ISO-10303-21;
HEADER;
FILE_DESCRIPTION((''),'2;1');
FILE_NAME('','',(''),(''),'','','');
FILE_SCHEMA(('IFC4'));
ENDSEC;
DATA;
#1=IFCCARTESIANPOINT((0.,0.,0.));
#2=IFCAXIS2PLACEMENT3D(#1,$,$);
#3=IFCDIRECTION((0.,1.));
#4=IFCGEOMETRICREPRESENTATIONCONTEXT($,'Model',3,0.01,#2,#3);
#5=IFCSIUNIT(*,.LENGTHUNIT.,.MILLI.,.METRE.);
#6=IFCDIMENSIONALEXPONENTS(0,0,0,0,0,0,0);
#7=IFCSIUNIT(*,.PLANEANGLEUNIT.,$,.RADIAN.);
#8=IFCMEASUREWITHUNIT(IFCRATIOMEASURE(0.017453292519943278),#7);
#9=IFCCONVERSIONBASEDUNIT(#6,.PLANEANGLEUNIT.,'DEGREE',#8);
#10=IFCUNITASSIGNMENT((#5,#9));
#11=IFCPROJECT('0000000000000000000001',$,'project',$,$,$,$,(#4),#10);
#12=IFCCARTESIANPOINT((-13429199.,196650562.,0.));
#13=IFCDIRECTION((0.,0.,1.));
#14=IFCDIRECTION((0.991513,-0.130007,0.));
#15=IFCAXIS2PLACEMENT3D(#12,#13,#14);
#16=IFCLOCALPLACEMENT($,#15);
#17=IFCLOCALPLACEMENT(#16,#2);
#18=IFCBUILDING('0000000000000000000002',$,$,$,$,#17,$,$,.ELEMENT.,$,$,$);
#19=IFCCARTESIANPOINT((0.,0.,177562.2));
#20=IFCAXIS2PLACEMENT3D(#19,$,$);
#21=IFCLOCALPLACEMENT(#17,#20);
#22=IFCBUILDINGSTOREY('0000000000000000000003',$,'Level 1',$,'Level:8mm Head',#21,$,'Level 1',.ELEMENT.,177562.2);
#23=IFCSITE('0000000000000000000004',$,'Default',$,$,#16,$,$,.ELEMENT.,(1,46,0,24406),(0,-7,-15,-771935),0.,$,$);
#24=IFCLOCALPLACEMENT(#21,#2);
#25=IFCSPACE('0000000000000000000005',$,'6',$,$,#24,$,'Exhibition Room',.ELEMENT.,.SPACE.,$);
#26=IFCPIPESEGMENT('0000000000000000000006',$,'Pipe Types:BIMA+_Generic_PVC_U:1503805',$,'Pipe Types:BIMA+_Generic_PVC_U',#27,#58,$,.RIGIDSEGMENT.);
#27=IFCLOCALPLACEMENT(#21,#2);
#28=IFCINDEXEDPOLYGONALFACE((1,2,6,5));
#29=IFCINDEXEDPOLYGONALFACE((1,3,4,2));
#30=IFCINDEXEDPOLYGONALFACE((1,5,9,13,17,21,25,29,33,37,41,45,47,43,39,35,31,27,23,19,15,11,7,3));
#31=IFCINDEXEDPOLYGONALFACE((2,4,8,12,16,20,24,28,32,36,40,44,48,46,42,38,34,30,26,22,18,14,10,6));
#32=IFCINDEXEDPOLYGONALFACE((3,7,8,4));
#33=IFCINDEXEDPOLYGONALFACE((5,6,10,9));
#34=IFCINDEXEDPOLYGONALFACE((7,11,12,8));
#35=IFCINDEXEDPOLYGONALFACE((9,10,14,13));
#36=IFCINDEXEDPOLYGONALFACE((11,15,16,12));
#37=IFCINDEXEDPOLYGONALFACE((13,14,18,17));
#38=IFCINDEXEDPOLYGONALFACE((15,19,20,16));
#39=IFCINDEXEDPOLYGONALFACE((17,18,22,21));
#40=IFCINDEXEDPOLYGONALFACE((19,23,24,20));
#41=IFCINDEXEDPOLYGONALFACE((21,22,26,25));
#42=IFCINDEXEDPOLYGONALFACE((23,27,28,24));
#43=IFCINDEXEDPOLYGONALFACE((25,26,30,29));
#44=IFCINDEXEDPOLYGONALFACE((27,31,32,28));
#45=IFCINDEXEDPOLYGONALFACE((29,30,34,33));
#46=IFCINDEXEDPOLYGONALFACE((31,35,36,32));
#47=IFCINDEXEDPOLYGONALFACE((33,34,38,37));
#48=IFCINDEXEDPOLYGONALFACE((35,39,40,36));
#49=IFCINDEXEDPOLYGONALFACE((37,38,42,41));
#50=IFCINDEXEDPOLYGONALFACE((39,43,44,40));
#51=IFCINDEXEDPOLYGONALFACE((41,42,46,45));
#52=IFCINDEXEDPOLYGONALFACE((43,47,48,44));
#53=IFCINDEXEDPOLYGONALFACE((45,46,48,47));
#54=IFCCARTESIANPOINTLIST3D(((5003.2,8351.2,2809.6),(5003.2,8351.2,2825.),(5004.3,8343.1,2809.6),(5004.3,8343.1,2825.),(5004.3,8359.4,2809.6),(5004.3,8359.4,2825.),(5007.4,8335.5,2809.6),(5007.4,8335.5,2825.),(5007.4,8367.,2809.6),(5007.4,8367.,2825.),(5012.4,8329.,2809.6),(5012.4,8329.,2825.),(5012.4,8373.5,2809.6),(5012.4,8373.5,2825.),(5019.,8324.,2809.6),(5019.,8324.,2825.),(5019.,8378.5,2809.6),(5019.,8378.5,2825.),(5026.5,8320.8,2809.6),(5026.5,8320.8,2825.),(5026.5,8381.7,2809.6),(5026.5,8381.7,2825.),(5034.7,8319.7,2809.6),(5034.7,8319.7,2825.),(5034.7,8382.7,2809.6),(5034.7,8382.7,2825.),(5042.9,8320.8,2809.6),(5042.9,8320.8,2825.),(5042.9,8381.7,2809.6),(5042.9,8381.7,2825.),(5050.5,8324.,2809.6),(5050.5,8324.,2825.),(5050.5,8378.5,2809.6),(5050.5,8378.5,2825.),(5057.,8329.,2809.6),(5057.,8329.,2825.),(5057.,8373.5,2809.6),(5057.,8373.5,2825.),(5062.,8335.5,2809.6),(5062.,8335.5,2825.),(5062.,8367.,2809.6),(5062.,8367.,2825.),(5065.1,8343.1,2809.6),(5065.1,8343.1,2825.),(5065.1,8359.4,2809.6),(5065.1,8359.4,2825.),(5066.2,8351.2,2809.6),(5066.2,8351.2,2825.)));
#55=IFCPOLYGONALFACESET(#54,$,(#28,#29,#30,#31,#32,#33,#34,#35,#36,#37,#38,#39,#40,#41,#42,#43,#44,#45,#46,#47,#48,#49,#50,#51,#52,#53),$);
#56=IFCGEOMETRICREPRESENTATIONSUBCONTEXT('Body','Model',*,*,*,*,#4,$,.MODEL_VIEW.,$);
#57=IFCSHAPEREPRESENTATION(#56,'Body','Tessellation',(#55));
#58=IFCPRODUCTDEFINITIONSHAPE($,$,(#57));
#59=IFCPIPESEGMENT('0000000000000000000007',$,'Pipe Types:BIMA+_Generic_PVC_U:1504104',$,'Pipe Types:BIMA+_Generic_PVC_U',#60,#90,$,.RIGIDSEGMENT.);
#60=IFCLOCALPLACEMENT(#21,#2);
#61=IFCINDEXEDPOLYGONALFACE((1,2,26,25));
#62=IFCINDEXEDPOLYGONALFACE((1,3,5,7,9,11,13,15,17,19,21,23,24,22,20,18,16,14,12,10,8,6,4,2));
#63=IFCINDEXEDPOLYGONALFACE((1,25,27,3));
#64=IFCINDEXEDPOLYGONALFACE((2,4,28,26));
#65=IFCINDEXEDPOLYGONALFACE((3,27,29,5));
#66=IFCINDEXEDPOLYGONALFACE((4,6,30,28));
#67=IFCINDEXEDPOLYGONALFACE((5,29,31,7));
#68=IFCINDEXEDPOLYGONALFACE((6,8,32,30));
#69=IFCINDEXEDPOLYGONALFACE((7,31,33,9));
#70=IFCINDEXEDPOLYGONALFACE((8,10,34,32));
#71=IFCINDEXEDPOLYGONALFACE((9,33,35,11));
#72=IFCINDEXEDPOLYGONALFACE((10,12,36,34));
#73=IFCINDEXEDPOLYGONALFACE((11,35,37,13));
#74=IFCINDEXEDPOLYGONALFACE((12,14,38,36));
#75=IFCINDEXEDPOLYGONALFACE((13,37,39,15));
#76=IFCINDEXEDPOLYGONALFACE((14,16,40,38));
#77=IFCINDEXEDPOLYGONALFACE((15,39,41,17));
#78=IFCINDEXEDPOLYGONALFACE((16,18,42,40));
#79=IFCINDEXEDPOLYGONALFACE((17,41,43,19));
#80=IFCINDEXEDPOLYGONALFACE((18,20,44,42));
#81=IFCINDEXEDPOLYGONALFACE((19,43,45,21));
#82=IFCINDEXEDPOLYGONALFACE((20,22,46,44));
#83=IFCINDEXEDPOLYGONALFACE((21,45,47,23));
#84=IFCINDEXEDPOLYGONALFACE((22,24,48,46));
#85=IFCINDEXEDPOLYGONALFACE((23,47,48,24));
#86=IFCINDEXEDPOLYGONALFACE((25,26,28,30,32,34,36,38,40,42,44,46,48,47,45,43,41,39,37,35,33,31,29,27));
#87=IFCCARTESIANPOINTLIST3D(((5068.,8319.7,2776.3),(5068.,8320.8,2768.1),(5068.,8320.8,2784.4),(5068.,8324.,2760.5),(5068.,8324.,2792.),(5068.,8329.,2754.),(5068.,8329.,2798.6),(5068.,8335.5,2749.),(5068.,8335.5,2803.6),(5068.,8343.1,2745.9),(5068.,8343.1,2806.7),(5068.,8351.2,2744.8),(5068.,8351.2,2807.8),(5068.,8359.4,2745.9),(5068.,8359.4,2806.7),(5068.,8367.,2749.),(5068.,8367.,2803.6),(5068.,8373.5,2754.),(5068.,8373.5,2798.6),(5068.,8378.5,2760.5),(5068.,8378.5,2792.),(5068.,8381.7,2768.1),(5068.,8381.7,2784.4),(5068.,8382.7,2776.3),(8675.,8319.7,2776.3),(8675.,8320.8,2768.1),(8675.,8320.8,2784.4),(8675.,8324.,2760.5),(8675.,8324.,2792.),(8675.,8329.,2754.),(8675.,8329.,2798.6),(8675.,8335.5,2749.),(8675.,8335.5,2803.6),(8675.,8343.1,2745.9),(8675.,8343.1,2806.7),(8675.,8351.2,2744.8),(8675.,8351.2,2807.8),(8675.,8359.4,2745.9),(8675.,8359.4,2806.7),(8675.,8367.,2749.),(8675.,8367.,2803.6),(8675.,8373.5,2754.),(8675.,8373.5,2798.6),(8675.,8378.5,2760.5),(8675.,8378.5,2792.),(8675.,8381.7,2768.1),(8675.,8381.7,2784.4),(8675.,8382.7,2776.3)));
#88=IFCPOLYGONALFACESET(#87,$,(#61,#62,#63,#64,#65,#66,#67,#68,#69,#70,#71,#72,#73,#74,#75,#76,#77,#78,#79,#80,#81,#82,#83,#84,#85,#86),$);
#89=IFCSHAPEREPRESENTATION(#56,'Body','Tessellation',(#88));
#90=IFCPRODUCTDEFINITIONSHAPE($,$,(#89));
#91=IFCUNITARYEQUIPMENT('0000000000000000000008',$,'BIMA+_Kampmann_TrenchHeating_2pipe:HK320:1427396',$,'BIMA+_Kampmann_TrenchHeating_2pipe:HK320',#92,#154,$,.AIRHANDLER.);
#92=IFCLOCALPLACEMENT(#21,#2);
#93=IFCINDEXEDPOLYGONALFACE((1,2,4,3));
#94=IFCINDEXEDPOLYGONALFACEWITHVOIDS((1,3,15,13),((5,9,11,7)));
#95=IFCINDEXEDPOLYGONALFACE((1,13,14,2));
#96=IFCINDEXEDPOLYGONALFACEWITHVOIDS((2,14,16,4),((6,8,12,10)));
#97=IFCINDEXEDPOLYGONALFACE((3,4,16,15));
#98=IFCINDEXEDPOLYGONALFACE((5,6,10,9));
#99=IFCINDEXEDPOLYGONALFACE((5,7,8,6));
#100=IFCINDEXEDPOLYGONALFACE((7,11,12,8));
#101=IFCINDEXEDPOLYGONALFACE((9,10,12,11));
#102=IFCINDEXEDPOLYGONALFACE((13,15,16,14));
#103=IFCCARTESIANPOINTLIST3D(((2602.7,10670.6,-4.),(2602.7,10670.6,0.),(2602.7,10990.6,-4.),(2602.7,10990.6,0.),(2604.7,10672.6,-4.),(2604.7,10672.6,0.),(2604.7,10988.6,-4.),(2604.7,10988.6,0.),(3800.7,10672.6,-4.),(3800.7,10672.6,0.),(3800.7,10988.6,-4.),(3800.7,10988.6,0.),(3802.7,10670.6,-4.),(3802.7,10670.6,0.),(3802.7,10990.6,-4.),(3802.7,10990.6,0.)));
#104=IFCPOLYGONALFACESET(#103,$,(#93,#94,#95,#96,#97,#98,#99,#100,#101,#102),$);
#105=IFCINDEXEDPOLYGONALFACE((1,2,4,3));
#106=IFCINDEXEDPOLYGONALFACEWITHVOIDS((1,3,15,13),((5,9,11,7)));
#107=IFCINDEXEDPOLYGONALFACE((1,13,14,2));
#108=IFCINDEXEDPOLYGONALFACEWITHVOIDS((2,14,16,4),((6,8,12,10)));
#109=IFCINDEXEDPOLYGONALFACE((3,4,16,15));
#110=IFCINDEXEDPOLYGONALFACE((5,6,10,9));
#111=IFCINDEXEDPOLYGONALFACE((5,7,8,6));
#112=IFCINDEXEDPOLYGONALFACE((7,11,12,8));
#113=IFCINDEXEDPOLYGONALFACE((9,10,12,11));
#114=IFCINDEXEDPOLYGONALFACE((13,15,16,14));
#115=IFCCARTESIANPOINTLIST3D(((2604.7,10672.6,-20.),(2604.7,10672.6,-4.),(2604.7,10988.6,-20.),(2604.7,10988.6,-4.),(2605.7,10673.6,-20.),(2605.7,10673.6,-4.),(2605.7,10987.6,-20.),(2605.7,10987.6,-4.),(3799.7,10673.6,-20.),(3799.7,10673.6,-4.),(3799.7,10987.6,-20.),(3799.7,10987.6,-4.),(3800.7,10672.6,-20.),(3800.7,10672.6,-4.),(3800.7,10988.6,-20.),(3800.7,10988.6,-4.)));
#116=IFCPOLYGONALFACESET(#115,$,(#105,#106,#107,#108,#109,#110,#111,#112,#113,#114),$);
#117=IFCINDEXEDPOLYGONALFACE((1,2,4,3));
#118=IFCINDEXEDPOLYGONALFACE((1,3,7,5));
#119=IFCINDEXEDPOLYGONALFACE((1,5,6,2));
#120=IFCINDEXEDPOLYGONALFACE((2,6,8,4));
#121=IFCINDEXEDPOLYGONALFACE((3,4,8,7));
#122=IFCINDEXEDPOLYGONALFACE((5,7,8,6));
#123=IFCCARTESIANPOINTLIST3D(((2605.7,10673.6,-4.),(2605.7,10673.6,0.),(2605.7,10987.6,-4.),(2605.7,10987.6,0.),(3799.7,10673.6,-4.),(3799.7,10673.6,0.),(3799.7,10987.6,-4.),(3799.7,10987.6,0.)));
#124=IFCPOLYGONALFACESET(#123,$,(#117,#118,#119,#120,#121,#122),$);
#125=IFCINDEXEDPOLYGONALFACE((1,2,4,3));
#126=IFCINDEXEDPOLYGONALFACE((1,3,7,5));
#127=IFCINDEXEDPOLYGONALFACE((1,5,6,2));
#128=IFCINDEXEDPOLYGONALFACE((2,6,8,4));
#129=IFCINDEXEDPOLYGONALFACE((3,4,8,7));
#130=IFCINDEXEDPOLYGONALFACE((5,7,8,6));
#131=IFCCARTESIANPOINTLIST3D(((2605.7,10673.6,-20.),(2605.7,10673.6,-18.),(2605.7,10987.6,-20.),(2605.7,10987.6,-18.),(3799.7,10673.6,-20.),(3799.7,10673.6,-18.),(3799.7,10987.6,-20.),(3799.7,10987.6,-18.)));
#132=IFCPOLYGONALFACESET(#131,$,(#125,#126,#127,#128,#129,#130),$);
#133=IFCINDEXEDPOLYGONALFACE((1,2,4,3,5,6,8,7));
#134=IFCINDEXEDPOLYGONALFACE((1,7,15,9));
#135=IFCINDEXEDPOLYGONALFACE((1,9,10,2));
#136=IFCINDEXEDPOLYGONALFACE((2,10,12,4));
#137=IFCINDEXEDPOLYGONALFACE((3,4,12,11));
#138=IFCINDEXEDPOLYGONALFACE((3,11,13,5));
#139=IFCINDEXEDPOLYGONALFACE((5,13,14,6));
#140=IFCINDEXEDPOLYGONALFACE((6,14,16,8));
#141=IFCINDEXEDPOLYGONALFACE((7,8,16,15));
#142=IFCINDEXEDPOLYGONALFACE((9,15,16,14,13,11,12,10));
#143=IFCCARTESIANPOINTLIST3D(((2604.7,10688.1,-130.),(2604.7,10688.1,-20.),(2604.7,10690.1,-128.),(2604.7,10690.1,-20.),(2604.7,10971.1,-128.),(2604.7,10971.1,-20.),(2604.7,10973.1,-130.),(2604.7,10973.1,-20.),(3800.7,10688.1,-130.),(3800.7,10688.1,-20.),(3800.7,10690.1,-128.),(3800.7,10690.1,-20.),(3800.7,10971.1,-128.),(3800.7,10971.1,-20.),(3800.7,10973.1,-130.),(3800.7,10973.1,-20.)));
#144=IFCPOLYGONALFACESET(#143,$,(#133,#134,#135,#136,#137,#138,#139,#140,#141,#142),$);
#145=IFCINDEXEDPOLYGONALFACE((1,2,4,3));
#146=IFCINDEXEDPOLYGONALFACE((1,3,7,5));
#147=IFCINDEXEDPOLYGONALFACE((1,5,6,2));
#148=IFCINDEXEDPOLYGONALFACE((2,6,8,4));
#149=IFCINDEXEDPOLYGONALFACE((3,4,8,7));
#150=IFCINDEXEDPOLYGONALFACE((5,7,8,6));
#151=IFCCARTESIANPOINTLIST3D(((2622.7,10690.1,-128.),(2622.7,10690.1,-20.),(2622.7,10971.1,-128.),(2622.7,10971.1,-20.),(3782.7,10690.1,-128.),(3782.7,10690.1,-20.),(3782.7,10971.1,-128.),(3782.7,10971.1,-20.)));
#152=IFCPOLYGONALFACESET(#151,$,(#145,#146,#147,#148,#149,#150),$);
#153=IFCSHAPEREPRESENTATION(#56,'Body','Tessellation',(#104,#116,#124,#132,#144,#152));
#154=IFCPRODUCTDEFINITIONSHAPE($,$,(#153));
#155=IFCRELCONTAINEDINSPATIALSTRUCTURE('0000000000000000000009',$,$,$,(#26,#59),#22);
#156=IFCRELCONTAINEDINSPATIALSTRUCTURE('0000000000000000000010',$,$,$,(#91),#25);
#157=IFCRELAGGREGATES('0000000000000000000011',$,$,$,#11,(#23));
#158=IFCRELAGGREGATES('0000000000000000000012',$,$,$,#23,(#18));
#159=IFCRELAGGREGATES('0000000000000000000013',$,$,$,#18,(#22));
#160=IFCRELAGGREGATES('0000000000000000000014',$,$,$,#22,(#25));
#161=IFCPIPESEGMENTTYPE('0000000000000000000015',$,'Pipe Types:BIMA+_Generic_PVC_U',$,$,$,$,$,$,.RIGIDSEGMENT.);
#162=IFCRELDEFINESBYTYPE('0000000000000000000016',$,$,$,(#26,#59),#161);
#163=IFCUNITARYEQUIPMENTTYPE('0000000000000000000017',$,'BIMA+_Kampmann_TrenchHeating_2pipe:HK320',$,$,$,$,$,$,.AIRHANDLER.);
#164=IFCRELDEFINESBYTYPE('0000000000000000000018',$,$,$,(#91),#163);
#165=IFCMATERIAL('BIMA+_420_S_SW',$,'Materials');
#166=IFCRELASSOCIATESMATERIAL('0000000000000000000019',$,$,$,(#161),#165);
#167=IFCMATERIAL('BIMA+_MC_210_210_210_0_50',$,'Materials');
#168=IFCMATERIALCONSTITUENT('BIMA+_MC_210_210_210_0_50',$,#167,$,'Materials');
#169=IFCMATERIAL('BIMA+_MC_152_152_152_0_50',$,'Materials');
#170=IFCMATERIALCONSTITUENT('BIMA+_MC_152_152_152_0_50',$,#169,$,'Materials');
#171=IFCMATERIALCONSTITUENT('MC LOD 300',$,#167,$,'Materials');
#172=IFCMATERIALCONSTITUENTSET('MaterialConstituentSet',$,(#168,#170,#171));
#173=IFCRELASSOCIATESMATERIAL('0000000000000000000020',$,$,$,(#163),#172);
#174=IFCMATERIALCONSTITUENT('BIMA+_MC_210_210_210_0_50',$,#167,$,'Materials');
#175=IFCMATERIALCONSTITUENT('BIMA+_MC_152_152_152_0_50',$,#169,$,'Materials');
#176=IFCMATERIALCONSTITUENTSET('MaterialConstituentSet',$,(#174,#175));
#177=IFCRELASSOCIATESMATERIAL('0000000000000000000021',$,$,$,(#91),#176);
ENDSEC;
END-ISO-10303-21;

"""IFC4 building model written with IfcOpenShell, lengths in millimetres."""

from ifc_helpers import new_model, entity, si_unit, converted_unit, direction, frame, origin, place, context, subcontext, project, spatial, arc, indexed_curve, outline, extrude, source, transform, mapped, material, constituent, constituent_set, type_object, type_shapes, element, save


model = new_model("IFC4")

# Units and contexts
model_context = context("Model", 3, precision=0.01, world=origin(), true_north=direction((0.0, 1.0)))
body_context = subcontext(model_context, "Body", "Model", "MODEL_VIEW")
ifc_project = project(units=[si_unit("LENGTHUNIT", "METRE", prefix="MILLI"), converted_unit("PLANEANGLEUNIT", "DEGREE", entity("IfcRatioMeasure", 0.017453292519943278), si_unit("PLANEANGLEUNIT", "RADIAN"), dimensions=[0, 0, 0, 0, 0, 0, 0])], contexts=[model_context])

# Site, building, storey
site_placement = place(None, frame((-13429199.0, 196650562.0, 0.0), z_axis=(0.0, 0.0, 1.0), x_axis=(0.991513, -0.130007, 0.0)))
site = spatial("IfcSite", under=ifc_project, at=site_placement, Name="Default", CompositionType="ELEMENT", RefLatitude=(1, 46, 0, 24406), RefLongitude=(0, -7, -15, -771935), RefElevation=0.0)
building_placement = place(site_placement, origin())
building = spatial("IfcBuilding", under=site, at=building_placement, CompositionType="ELEMENT")
storey_placement = place(building_placement, frame((0.0, 0.0, 177562.2)))
storey = spatial("IfcBuildingStorey", under=building, at=storey_placement, Name="Level 1", ObjectType="Level:8mm Head", LongName="Level 1", CompositionType="ELEMENT", Elevation=177562.2)

# Pipe segments
ifc_material_1 = material(Name="BIMA+_420_S_SW", Category="Materials")
pipe_segment_type_1 = type_object("IfcPipeSegmentType", Name="Pipe Types:BIMA+_Generic_PVC_U", PredefinedType="RIGIDSEGMENT", material=ifc_material_1)
pipe_segment_1_placement = place(storey_placement, frame((5001.6, 8318.2, 2825.0)))
element("IfcPipeSegment", 1, at=pipe_segment_1_placement, inside=storey, type_object=pipe_segment_type_1, Name="Pipe Types:BIMA+_Generic_PVC_U:1503805", ObjectType="Pipe Types:BIMA+_Generic_PVC_U", PredefinedType="RIGIDSEGMENT", context=body_context, shape_type="SweptSolid", body=[
    extrude(outline(indexed_curve([(31.5, 0.0), (22.3, 22.3), (0.0, 31.5), (-22.3, 22.3), (-31.5, 0.0), (-22.3, -22.3), (0.0, -31.5), (22.3, -22.3)], segments=[arc(1, 2, 3), arc(3, 4, 5), arc(5, 6, 7), arc(7, 8, 1)], self_intersect=False)), frame((33.1, 33.1, -15.4)), (0.0, 0.0, 1.0), 15.4),
])
pipe_segment_2_placement = place(storey_placement, frame((5068.0, 8318.2, 2743.2)))
element("IfcPipeSegment", 2, at=pipe_segment_2_placement, inside=storey, type_object=pipe_segment_type_1, Name="Pipe Types:BIMA+_Generic_PVC_U:1504104", ObjectType="Pipe Types:BIMA+_Generic_PVC_U", PredefinedType="RIGIDSEGMENT", context=body_context, shape_type="SweptSolid", body=[
    extrude(outline(indexed_curve([(31.5, 0.0), (22.3, 22.3), (0.0, 31.5), (-22.3, 22.3), (-31.5, 0.0), (-22.3, -22.3), (0.0, -31.5), (22.3, -22.3)], segments=[arc(1, 2, 3), arc(3, 4, 5), arc(5, 6, 7), arc(7, 8, 1)], self_intersect=False)), frame((0.0, 33.1, 33.1), z_axis=(1.0, 0.0, 0.0), x_axis=(0.0, -1.0, 0.0)), (0.0, 0.0, 1.0), 3607.0),
])

# Shared definitions
space_placement = place(storey_placement, origin())
space = spatial("IfcSpace", under=storey, at=space_placement, Name="6", LongName="Exhibition Room", CompositionType="ELEMENT", PredefinedType="SPACE")

# Unitary equipment
ifc_material_2 = material(Name="BIMA+_MC_210_210_210_0_50", Category="Materials")
ifc_constituent_1 = constituent(ifc_material_2, Name="BIMA+_MC_210_210_210_0_50", Category="Materials")
ifc_material_3 = material(Name="BIMA+_MC_152_152_152_0_50", Category="Materials")
ifc_constituent_2 = constituent(ifc_material_3, Name="BIMA+_MC_152_152_152_0_50", Category="Materials")
ifc_constituent_set_1 = constituent_set(constituents=[ifc_constituent_1, ifc_constituent_2], Name="MaterialConstituentSet")
ifc_constituent_3 = constituent(ifc_material_2, Name="BIMA+_MC_210_210_210_0_50", Category="Materials")
ifc_constituent_4 = constituent(ifc_material_3, Name="BIMA+_MC_152_152_152_0_50", Category="Materials")
ifc_constituent_5 = constituent(ifc_material_2, Name="MC LOD 300", Category="Materials")
ifc_constituent_set_2 = constituent_set(constituents=[ifc_constituent_3, ifc_constituent_4, ifc_constituent_5], Name="MaterialConstituentSet")
unitary_equipment_type = type_object("IfcUnitaryEquipmentType", Name="BIMA+_Kampmann_TrenchHeating_2pipe:HK320", PredefinedType="AIRHANDLER", material=ifc_constituent_set_2)
shared_shape = source(origin(), body_context, "Body", "SweptSolid", [
    extrude(outline(indexed_curve([(-160.0, -600.0), (160.0, -600.0), (160.0, 600.0), (-160.0, 600.0), (-160.0, -600.0)], self_intersect=False), holes=[indexed_curve([(-158.0, 598.0), (158.0, 598.0), (158.0, -598.0), (-158.0, -598.0), (-158.0, 598.0)], self_intersect=False)]), frame((0.0, 0.0, -4.0), z_axis=(0.0, 0.0, 1.0), x_axis=(0.0, -1.0, 0.0)), (0.0, 0.0, 1.0), 4.0),
    extrude(outline(indexed_curve([(-598.0, -158.0), (598.0, -158.0), (598.0, 158.0), (-598.0, 158.0), (-598.0, -158.0)], self_intersect=False), holes=[indexed_curve([(-597.0, -157.0), (-597.0, 157.0), (597.0, 157.0), (597.0, -157.0), (-597.0, -157.0)], self_intersect=False)]), frame((0.0, 0.0, -20.0), z_axis=(0.0, 0.0, 1.0), x_axis=(-1.0, 0.0, 0.0)), (0.0, 0.0, 1.0), 16.0),
    extrude(outline(indexed_curve([(-597.0, -157.0), (597.0, -157.0), (597.0, 157.0), (-597.0, 157.0), (-597.0, -157.0)], self_intersect=False)), frame((0.0, 0.0, -4.0), z_axis=(0.0, 0.0, 1.0), x_axis=(-1.0, 0.0, 0.0)), (0.0, 0.0, 1.0), 4.0),
    extrude(outline(indexed_curve([(-597.0, -157.0), (597.0, -157.0), (597.0, 157.0), (-597.0, 157.0), (-597.0, -157.0)], self_intersect=False)), frame((0.0, 0.0, -20.0), z_axis=(0.0, 0.0, 1.0), x_axis=(-1.0, 0.0, 0.0)), (0.0, 0.0, 1.0), 2.0),
    extrude(outline(indexed_curve([(-55.5, -142.5), (54.5, -142.5), (54.5, -140.5), (-53.5, -140.5), (-53.5, 140.5), (54.5, 140.5), (54.5, 142.5), (-55.5, 142.5), (-55.5, -142.5)], self_intersect=False)), frame((-598.0, 0.0, -74.5), z_axis=(1.0, 0.0, 0.0), x_axis=(0.0, 0.0, 1.0)), (0.0, 0.0, 1.0), 1196.0),
    extrude(outline(indexed_curve([(-580.0, -140.5), (580.0, -140.5), (580.0, 140.5), (-580.0, 140.5), (-580.0, -140.5)], self_intersect=False)), frame((0.0, 0.0, -128.0), z_axis=(0.0, 0.0, 1.0), x_axis=(-1.0, 0.0, 0.0)), (0.0, 0.0, 1.0), 108.0),
])
type_shapes(unitary_equipment_type, [shared_shape])
unitary_equipment_1_placement = place(space_placement, frame((3202.7, 10830.6, 0.0), z_axis=(0.0, 0.0, 1.0), x_axis=(-1.0, 0.0, 0.0)))
element("IfcUnitaryEquipment", 3, at=unitary_equipment_1_placement, inside=space, type_object=unitary_equipment_type, material=ifc_constituent_set_1, Name="BIMA+_Kampmann_TrenchHeating_2pipe:HK320:1427396", ObjectType="BIMA+_Kampmann_TrenchHeating_2pipe:HK320", PredefinedType="AIRHANDLER", context=body_context, shape_type="MappedRepresentation", body=[
    mapped(shared_shape, transform((0.0, 0.0, 0.0), scale=1.0)),
])

save(model, "model.ifc")
